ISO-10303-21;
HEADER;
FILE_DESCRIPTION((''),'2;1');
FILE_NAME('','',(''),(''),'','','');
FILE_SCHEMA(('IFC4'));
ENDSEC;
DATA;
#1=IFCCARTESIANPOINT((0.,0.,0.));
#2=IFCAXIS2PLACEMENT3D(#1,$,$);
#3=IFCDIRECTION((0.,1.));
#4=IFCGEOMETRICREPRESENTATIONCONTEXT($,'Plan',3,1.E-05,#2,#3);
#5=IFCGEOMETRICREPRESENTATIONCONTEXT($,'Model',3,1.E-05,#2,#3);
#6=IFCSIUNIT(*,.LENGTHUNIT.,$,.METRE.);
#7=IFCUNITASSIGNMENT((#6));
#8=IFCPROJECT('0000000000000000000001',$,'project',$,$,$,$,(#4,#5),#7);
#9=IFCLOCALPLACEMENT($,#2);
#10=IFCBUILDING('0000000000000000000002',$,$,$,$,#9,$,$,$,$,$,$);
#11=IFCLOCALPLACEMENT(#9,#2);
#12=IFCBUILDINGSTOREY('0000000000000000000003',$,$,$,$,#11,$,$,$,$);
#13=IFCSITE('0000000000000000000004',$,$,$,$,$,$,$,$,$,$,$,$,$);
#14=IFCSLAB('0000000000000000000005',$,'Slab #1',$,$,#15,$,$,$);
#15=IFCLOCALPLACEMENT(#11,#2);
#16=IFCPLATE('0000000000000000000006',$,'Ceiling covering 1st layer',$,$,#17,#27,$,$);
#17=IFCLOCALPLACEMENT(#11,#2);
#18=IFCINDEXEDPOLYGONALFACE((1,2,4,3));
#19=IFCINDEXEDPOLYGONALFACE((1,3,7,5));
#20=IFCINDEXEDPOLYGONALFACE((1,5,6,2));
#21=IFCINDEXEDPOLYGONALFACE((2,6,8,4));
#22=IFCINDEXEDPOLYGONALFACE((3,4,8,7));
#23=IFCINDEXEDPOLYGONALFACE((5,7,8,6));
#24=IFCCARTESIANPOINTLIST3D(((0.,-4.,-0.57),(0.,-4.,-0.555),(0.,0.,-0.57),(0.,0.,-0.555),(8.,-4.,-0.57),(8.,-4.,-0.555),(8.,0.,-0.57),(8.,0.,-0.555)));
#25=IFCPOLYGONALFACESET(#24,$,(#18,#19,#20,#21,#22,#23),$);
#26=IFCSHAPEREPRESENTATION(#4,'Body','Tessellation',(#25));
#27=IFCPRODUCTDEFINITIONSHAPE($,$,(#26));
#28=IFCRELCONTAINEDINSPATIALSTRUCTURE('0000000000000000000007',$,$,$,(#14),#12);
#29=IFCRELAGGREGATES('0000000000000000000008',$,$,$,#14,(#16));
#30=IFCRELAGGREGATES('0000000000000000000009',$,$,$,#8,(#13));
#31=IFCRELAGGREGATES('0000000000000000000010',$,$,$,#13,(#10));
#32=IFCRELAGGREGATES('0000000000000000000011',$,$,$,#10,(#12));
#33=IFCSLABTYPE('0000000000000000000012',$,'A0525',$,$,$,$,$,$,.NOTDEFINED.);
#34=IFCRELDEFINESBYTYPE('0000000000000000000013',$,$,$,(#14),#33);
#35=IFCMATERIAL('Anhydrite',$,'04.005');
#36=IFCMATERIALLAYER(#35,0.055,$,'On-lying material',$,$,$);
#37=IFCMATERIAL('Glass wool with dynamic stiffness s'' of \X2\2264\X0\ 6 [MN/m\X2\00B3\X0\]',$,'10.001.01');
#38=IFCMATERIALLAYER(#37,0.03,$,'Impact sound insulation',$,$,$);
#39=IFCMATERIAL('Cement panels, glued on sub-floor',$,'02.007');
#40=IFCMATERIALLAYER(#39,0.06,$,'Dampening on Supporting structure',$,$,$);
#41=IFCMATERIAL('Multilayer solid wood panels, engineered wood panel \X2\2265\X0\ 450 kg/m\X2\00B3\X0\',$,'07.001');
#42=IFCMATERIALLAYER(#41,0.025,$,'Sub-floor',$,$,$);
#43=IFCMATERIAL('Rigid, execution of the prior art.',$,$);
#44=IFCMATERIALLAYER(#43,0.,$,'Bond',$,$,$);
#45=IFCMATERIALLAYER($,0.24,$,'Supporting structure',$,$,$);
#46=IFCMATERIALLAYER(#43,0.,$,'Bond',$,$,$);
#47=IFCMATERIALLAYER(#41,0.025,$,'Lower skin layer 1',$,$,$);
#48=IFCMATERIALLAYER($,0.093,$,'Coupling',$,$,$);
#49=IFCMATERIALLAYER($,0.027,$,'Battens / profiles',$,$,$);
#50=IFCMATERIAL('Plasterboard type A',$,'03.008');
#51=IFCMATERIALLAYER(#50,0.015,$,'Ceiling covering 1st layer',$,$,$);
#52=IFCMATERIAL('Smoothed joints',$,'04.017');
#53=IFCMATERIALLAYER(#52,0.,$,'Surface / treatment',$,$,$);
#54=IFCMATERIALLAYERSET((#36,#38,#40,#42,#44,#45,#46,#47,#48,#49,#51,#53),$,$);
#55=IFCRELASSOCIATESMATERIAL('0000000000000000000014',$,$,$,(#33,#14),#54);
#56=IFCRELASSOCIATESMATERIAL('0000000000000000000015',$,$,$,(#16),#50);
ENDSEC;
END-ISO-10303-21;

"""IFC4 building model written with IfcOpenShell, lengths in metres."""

from ifc_helpers import new_model, si_unit, direction, frame, frame_2d, origin, place, context, project, spatial, rectangle, extrude, material, layer, layer_set, type_object, element, aggregate, save


model = new_model("IFC4")

# Units and contexts
plan_context = context("Plan", 3, precision=1e-05, world=origin(), true_north=direction((0.0, 1.0)))
model_context = context("Model", 3, precision=1e-05, world=origin(), true_north=direction((0.0, 1.0)))
ifc_project = project(units=[si_unit("LENGTHUNIT", "METRE")], contexts=[plan_context, model_context])

# Site, building, storey
site = spatial("IfcSite", under=ifc_project)
building_placement = place(None, origin())
building = spatial("IfcBuilding", under=site, at=building_placement)
storey_placement = place(building_placement, origin())
storey = spatial("IfcBuildingStorey", under=building, at=storey_placement)

# Slab, plate
ifc_material_1 = material(Name="Anhydrite", Category="04.005")
ifc_layer_1 = layer(ifc_material_1, 0.055, Name="On-lying material")
ifc_material_2 = material(Name="Glass wool with dynamic stiffness s' of ≤ 6 [MN/m³]", Category="10.001.01")
ifc_layer_2 = layer(ifc_material_2, 0.03, Name="Impact sound insulation")
ifc_material_3 = material(Name="Cement panels, glued on sub-floor", Category="02.007")
ifc_layer_3 = layer(ifc_material_3, 0.06, Name="Dampening on Supporting structure")
ifc_material_4 = material(Name="Multilayer solid wood panels, engineered wood panel ≥ 450 kg/m³", Category="07.001")
ifc_layer_4 = layer(ifc_material_4, 0.025, Name="Sub-floor")
ifc_material_5 = material(Name="Rigid, execution of the prior art.")
ifc_layer_5 = layer(ifc_material_5, 0.0, Name="Bond")
ifc_layer_6 = layer(None, 0.24, Name="Supporting structure")
ifc_layer_7 = layer(ifc_material_5, 0.0, Name="Bond")
ifc_layer_8 = layer(ifc_material_4, 0.025, Name="Lower skin layer 1")
ifc_layer_9 = layer(None, 0.093, Name="Coupling")
ifc_layer_10 = layer(None, 0.027, Name="Battens / profiles")
ifc_material_6 = material(Name="Plasterboard type A", Category="03.008")
ifc_layer_11 = layer(ifc_material_6, 0.015, Name="Ceiling covering 1st layer")
ifc_material_7 = material(Name="Smoothed joints", Category="04.017")
ifc_layer_12 = layer(ifc_material_7, 0.0, Name="Surface / treatment")
ifc_layer_set = layer_set([ifc_layer_1, ifc_layer_2, ifc_layer_3, ifc_layer_4, ifc_layer_5, ifc_layer_6, ifc_layer_7, ifc_layer_8, ifc_layer_9, ifc_layer_10, ifc_layer_11, ifc_layer_12])
slab_type = type_object("IfcSlabType", Name="A0525", PredefinedType="NOTDEFINED", material=ifc_layer_set)
slab_placement = place(None, frame((0.0, 0.0, 0.0), z_axis=(0.0, 0.0, -1.0), x_axis=(1.0, 0.0, 0.0)))
slab = element("IfcSlab", 1, at=slab_placement, inside=storey, type_object=slab_type, material=ifc_layer_set, Name="Slab #1")
plate_1_placement = place(slab_placement, origin())
plate_1 = element("IfcPlate", 2, at=plate_1_placement, material=ifc_material_6, Name="Ceiling covering 1st layer", context=plan_context, shape_type="SweptSolid", body=[
    extrude(rectangle(XDim=8.0, YDim=4.0, at=frame_2d((4.0, 2.0), x_axis=(1.0, 0.0))), frame((0.0, 0.0, 0.555), z_axis=(0.0, 0.0, 1.0), x_axis=(1.0, 0.0, 0.0)), (0.0, 0.0, 1.0), 0.015),
])
aggregate(slab, [plate_1])

save(model, "model.ifc")
